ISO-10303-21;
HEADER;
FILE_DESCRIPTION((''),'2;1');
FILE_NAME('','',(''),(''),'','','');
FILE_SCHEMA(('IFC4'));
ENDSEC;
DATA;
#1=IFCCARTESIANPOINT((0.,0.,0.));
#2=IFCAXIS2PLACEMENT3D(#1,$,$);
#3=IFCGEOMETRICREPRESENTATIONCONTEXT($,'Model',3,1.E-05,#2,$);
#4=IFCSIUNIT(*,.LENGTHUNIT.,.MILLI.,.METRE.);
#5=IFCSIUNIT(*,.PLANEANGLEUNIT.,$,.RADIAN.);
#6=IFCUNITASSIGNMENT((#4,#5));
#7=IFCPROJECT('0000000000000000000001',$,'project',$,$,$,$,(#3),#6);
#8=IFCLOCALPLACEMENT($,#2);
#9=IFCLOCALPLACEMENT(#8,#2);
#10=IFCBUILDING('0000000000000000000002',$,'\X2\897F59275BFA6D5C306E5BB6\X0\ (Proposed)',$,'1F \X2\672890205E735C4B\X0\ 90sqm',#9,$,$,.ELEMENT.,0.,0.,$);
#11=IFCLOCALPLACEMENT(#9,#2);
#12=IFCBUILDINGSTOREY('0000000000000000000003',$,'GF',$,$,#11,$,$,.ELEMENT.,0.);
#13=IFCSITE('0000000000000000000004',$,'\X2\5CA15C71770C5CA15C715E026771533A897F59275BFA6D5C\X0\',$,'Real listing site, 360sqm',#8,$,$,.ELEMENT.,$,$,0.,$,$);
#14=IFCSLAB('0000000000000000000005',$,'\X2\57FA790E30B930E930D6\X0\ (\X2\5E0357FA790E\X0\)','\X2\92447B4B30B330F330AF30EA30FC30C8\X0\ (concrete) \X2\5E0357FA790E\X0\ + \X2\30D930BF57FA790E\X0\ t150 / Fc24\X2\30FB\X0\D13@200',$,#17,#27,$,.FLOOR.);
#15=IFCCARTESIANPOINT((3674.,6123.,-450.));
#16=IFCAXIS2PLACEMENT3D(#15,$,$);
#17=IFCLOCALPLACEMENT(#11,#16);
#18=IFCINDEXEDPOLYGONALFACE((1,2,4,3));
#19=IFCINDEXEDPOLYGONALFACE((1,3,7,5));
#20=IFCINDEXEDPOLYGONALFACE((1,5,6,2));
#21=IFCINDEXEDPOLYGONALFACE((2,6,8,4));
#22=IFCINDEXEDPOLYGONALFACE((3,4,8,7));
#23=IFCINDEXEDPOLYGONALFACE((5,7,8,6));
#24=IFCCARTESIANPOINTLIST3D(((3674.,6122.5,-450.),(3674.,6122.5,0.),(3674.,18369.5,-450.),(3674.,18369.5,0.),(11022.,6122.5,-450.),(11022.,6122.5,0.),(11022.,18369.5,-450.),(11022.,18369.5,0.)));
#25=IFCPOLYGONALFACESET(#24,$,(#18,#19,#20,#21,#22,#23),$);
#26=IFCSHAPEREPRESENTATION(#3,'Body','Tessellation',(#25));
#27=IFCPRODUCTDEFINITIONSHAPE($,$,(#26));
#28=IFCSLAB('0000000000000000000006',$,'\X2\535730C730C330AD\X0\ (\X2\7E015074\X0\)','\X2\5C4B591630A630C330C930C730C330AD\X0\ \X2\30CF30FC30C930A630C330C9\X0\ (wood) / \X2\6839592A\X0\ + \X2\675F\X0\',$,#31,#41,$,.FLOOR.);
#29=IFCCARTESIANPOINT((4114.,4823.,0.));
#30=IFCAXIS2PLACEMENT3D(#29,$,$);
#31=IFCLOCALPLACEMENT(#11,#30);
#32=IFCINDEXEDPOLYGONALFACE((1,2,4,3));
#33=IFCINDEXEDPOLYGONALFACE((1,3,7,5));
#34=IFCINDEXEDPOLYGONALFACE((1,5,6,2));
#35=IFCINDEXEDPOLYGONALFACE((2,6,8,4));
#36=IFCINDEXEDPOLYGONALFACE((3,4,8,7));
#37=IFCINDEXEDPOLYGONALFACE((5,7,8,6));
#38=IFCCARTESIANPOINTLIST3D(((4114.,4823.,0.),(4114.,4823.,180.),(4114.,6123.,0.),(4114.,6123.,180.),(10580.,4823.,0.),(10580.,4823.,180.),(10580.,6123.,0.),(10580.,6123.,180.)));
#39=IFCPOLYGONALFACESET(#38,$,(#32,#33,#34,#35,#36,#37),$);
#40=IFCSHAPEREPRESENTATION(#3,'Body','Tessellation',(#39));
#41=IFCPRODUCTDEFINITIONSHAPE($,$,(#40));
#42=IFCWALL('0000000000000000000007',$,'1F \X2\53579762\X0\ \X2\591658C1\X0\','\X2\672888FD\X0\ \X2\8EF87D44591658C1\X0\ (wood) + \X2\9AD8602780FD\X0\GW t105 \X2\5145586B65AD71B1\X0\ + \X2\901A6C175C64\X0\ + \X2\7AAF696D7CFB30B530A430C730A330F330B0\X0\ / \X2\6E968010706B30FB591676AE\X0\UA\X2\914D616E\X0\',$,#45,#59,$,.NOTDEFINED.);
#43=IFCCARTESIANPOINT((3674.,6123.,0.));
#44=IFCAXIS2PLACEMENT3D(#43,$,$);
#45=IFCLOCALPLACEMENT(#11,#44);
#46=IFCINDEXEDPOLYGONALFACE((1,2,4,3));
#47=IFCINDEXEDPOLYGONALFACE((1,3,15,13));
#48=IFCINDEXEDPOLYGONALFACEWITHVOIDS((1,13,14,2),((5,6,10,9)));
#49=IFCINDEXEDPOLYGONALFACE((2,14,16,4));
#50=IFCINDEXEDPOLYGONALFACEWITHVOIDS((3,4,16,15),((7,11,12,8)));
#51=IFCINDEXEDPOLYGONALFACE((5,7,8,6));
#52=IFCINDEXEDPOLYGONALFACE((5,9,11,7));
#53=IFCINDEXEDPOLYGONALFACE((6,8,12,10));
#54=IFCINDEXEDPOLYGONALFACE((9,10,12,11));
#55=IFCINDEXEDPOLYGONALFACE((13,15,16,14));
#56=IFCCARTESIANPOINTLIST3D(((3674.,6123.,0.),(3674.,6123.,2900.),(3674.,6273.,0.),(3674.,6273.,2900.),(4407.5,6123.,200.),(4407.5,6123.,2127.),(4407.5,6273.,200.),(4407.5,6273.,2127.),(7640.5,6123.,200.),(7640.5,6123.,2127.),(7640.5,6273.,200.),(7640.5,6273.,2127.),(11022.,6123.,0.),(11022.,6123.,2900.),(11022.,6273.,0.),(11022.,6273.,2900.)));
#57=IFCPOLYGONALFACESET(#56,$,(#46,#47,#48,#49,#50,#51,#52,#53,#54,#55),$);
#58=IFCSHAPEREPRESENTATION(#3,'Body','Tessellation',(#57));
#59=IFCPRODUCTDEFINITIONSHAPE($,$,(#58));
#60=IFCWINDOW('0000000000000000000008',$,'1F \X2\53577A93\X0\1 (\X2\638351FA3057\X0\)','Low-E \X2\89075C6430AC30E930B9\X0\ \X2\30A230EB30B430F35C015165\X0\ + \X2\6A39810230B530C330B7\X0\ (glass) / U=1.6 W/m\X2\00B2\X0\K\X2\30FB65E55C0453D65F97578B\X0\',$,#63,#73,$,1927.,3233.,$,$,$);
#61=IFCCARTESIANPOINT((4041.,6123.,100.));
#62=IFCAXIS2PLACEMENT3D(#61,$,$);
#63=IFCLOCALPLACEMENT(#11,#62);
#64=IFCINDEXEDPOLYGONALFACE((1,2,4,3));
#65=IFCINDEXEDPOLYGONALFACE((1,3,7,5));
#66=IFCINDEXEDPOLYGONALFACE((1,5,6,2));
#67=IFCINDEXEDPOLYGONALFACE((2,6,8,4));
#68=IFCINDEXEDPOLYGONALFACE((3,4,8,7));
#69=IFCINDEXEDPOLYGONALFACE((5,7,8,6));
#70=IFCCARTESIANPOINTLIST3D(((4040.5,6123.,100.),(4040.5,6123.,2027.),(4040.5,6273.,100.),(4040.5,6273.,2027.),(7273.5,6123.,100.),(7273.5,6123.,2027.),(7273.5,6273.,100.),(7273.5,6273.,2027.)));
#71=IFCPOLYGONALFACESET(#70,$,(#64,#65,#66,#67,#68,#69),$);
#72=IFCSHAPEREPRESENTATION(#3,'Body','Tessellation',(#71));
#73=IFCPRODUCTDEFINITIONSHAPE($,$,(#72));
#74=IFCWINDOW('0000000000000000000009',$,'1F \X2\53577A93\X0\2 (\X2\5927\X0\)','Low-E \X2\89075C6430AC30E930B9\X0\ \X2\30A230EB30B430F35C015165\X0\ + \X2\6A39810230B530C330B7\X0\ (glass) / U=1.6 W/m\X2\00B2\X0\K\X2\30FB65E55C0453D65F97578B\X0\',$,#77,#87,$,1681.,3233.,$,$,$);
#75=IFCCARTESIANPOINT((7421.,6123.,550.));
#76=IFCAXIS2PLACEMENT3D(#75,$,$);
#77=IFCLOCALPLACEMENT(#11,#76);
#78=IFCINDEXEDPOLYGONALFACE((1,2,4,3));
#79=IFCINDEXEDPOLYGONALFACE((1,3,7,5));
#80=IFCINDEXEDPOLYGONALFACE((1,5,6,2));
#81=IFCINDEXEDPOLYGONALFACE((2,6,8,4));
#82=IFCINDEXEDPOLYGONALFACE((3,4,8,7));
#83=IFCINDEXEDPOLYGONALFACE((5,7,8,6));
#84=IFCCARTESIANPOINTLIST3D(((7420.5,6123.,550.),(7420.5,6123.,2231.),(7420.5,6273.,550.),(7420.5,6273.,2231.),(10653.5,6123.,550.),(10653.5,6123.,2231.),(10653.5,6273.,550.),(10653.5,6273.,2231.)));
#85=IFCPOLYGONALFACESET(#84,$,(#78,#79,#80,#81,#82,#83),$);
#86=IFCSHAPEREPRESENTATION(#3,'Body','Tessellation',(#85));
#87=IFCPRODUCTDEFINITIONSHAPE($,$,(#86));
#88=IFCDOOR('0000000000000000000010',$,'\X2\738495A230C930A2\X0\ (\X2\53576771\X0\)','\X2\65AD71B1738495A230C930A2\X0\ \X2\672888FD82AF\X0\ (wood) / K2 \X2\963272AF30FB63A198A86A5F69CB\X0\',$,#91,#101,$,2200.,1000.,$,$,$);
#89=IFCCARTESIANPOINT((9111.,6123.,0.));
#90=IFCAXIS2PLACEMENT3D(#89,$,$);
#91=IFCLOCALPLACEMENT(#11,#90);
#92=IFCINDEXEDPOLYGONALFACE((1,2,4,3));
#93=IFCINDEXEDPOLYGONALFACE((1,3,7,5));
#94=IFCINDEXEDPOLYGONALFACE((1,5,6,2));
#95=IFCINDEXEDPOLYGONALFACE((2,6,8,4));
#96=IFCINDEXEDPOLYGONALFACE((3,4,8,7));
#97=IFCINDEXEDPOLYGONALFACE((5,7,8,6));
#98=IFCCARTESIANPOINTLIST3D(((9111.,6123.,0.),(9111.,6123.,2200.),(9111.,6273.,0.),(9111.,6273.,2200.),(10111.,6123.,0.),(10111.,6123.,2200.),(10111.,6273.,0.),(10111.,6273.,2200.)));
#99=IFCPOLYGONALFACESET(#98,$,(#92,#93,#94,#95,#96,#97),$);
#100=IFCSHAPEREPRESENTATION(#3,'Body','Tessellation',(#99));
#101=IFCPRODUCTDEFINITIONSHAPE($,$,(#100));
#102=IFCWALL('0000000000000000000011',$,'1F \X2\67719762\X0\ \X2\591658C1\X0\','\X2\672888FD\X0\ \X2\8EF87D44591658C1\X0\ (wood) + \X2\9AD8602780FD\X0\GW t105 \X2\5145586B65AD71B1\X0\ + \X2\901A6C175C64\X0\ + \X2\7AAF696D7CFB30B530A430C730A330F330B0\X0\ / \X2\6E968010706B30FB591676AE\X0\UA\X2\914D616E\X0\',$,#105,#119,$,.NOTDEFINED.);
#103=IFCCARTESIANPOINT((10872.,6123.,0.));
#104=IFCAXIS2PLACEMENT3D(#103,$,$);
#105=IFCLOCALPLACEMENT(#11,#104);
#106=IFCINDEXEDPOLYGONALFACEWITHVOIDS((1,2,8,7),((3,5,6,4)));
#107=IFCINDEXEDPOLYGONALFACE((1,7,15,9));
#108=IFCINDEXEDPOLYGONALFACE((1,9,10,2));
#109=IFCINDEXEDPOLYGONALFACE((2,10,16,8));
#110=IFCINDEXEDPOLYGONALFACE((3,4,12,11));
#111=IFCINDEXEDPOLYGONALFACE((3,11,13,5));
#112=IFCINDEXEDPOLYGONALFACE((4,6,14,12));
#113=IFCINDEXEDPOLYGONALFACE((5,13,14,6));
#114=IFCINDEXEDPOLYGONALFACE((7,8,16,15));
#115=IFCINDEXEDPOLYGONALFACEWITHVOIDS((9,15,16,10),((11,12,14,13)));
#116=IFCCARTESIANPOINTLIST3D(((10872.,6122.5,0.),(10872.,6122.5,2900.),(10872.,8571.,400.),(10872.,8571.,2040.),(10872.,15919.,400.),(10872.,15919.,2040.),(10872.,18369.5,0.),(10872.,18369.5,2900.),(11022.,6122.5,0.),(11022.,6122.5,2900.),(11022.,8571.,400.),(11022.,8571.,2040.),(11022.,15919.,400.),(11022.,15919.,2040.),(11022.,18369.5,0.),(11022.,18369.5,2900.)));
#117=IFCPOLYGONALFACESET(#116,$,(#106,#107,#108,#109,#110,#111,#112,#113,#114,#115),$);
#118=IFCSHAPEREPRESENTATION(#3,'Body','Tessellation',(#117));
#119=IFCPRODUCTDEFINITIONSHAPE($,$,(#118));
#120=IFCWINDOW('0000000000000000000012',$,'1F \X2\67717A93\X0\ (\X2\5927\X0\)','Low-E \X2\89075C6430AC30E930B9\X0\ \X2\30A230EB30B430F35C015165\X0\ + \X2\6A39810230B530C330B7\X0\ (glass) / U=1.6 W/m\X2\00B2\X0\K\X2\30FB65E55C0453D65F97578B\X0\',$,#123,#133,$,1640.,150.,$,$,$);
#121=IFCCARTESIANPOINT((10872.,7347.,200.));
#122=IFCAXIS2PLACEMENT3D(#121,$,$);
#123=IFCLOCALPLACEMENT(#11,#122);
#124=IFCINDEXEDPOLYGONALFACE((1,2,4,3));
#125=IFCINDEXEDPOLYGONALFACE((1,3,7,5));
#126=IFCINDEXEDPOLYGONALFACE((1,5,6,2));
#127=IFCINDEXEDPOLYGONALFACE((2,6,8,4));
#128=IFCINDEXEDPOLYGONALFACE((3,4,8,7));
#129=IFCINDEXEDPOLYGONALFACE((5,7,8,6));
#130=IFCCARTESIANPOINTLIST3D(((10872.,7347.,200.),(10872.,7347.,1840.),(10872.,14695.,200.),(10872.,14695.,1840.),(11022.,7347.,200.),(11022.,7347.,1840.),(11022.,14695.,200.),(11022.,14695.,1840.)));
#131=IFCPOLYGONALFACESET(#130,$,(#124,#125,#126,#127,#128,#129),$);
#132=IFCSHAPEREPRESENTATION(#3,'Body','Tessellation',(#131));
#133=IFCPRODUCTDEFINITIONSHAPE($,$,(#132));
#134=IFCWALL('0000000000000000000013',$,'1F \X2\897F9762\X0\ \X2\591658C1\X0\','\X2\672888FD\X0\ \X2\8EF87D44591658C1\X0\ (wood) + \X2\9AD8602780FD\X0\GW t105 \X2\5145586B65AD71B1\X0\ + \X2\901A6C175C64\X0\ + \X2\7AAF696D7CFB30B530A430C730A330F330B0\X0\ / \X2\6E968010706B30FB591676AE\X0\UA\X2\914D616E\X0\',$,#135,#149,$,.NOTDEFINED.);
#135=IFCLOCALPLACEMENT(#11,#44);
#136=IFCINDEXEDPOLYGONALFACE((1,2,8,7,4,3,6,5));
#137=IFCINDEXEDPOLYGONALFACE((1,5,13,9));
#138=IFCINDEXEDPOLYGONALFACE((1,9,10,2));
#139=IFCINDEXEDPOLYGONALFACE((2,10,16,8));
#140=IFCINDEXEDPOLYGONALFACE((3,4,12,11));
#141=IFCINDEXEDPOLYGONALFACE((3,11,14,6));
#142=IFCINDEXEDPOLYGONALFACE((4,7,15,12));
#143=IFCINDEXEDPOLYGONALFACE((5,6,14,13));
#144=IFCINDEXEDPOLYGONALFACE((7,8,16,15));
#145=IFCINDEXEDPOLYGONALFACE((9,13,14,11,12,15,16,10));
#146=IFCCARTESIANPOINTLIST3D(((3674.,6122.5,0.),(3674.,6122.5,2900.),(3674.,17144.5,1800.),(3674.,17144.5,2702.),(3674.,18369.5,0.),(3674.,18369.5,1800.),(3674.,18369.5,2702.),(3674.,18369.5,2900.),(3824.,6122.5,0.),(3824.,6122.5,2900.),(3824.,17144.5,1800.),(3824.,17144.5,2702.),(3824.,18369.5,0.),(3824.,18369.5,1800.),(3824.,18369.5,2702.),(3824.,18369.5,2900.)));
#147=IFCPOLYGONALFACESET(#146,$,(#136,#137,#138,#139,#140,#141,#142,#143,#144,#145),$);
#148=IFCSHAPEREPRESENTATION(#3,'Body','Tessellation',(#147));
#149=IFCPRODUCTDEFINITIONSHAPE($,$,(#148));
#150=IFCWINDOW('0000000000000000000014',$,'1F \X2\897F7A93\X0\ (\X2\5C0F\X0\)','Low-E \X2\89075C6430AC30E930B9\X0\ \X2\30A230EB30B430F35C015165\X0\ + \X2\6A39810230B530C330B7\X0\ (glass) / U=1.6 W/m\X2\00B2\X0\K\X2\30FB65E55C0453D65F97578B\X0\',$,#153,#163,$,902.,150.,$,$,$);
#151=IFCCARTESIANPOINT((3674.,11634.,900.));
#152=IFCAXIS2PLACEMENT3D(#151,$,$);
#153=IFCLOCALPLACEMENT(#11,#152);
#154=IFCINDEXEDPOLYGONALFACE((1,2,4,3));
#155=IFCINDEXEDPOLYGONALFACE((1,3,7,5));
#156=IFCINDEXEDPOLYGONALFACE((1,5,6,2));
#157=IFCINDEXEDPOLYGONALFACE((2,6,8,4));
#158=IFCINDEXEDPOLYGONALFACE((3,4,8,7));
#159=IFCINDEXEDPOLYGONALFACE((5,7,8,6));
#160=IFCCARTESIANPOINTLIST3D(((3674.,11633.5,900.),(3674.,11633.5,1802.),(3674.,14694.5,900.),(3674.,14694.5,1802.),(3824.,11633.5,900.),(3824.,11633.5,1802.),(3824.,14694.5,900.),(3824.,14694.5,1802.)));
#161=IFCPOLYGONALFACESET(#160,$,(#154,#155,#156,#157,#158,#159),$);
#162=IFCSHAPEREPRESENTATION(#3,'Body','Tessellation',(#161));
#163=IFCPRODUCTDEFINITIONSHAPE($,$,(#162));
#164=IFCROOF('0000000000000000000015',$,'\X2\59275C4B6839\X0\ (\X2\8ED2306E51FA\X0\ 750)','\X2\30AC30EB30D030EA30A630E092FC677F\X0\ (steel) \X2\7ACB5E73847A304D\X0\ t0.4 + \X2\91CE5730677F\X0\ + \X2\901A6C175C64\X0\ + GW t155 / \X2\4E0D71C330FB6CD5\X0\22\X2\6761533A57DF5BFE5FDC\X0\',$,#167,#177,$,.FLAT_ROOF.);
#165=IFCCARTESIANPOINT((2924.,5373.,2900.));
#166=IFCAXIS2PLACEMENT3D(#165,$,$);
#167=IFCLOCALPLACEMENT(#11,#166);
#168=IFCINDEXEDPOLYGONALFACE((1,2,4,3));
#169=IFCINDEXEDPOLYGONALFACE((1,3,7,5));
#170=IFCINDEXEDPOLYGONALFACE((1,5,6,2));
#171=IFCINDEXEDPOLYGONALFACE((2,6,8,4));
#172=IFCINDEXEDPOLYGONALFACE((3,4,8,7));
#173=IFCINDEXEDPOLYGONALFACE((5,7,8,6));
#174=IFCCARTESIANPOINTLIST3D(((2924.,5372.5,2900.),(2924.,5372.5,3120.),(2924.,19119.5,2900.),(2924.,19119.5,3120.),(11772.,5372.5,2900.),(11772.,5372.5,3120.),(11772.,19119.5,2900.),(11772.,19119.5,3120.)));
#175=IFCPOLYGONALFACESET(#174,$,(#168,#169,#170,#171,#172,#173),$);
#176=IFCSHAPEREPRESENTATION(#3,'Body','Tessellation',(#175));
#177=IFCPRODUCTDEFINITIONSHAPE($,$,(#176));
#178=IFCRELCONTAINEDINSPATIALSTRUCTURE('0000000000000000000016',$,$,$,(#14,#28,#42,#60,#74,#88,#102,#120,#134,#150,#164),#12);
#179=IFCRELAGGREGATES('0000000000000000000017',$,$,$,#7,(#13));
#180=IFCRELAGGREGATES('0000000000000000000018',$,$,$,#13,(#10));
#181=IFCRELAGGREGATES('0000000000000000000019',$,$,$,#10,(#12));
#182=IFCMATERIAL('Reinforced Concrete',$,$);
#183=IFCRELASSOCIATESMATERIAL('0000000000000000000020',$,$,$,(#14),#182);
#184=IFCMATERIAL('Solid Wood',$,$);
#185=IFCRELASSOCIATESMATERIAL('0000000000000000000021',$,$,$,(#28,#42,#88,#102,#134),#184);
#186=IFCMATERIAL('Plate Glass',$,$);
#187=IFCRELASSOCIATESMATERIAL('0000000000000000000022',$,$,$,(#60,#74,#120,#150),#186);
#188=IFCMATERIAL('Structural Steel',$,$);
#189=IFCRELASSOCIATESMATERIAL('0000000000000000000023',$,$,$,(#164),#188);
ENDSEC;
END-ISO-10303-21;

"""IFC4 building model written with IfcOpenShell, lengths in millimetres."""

from ifc_helpers import new_model, si_unit, frame, frame_2d, origin, place, context, project, spatial, rectangle, extrude, material, element, fill, save


model = new_model("IFC4")

# Units and contexts
model_context = context("Model", 3, precision=1e-05, world=origin())
ifc_project = project(units=[si_unit("LENGTHUNIT", "METRE", prefix="MILLI"), si_unit("PLANEANGLEUNIT", "RADIAN")], contexts=[model_context])

# Site, building, storey
site_placement = place(None, origin())
site = spatial("IfcSite", under=ifc_project, at=site_placement, Name="岡山県岡山市東区西大寺浜", ObjectType="Real listing site, 360sqm", CompositionType="ELEMENT", RefElevation=0.0)
building_placement = place(site_placement, origin())
building = spatial("IfcBuilding", under=site, at=building_placement, Name="西大寺浜の家 (Proposed)", ObjectType="1F 木造平屋 90sqm", CompositionType="ELEMENT", ElevationOfRefHeight=0.0, ElevationOfTerrain=0.0)
storey_placement = place(building_placement, origin())
storey = spatial("IfcBuildingStorey", under=building, at=storey_placement, Name="GF", CompositionType="ELEMENT", Elevation=0.0)

# Slabs
ifc_material_1 = material(Name="Reinforced Concrete")
slab_1_placement = place(storey_placement, frame((3674.0, 6123.0, -450.0)))
element("IfcSlab", 1, at=slab_1_placement, inside=storey, material=ifc_material_1, Name="基礎スラブ (布基礎)", Description="鉄筋コンクリート (concrete) 布基礎 + ベタ基礎 t150 / Fc24・D13@200", PredefinedType="FLOOR", context=model_context, shape_type="SweptSolid", body=[
    extrude(rectangle(XDim=7348.0, YDim=12247.0, at=frame_2d((3674.0, 6123.0))), frame((3674.0, 6123.0, -450.0)), (0.0, 0.0, 1.0), 450.0),
])
ifc_material_2 = material(Name="Solid Wood")
slab_2_placement = place(storey_placement, frame((4114.0, 4823.0, 0.0)))
element("IfcSlab", 2, at=slab_2_placement, inside=storey, material=ifc_material_2, Name="南デッキ (縁側)", Description="屋外ウッドデッキ ハードウッド (wood) / 根太 + 束", PredefinedType="FLOOR", context=model_context, shape_type="SweptSolid", body=[
    extrude(rectangle(XDim=6466.0, YDim=1300.0, at=frame_2d((3233.0, 650.0))), frame((4114.0, 4823.0, 0.0)), (0.0, 0.0, 1.0), 180.0),
])

# Wall, openings, windows, door
wall_1_placement = place(storey_placement, frame((3674.0, 6123.0, 0.0)))
wall_1 = element("IfcWall", 3, at=wall_1_placement, inside=storey, material=ifc_material_2, Name="1F 南面 外壁", Description="木製 軸組外壁 (wood) + 高性能GW t105 充填断熱 + 通気層 + 窯業系サイディング / 準耐火・外皮UA配慮", PredefinedType="NOTDEFINED", context=model_context, shape_type="SweptSolid", body=[
    extrude(rectangle(XDim=7348.0, YDim=150.0, at=frame_2d((3674.0, 75.0))), frame((3674.0, 6123.0, 0.0)), (0.0, 0.0, 1.0), 2900.0),
])
opening_1_placement = place(storey_placement, frame((4041.0, 6123.0, 100.0)))
opening_1 = element("IfcOpeningElement", 4, at=opening_1_placement, cuts=wall_1, PredefinedType="NOTDEFINED", context=model_context, shape_type="SweptSolid", body=[
    extrude(rectangle(XDim=3233.0, YDim=150.0, at=frame_2d((1616.0, 75.0))), frame((4041.0, 6123.0, 100.0)), (0.0, 0.0, 1.0), 1927.0),
])
opening_2_placement = place(storey_placement, frame((7421.0, 6123.0, 550.0)))
opening_2 = element("IfcOpeningElement", 5, at=opening_2_placement, cuts=wall_1, PredefinedType="NOTDEFINED", context=model_context, shape_type="SweptSolid", body=[
    extrude(rectangle(XDim=3233.0, YDim=150.0, at=frame_2d((1616.0, 75.0))), frame((7421.0, 6123.0, 550.0)), (0.0, 0.0, 1.0), 1681.0),
])
opening_3_placement = place(storey_placement, frame((9111.0, 6123.0, 0.0)))
opening_3 = element("IfcOpeningElement", 6, at=opening_3_placement, cuts=wall_1, PredefinedType="NOTDEFINED", context=model_context, shape_type="SweptSolid", body=[
    extrude(rectangle(XDim=1000.0, YDim=150.0, at=frame_2d((500.0, 75.0))), frame((9111.0, 6123.0, 0.0)), (0.0, 0.0, 1.0), 2200.0),
])
ifc_material_3 = material(Name="Plate Glass")
window_1_placement = place(storey_placement, frame((4041.0, 6123.0, 100.0)))
window_1 = element("IfcWindow", 7, at=window_1_placement, inside=storey, material=ifc_material_3, Name="1F 南窓1 (掃出し)", Description="Low-E 複層ガラス アルゴン封入 + 樹脂サッシ (glass) / U=1.6 W/m²K・日射取得型", OverallHeight=1927.0, OverallWidth=3233.0, context=model_context, shape_type="SweptSolid", body=[
    extrude(rectangle(XDim=3233.0, YDim=150.0, at=frame_2d((1616.0, 75.0))), frame((4041.0, 6123.0, 100.0)), (0.0, 0.0, 1.0), 1927.0),
])
fill(opening_1, window_1)
window_2_placement = place(storey_placement, frame((7421.0, 6123.0, 550.0)))
window_2 = element("IfcWindow", 8, at=window_2_placement, inside=storey, material=ifc_material_3, Name="1F 南窓2 (大)", Description="Low-E 複層ガラス アルゴン封入 + 樹脂サッシ (glass) / U=1.6 W/m²K・日射取得型", OverallHeight=1681.0, OverallWidth=3233.0, context=model_context, shape_type="SweptSolid", body=[
    extrude(rectangle(XDim=3233.0, YDim=150.0, at=frame_2d((1616.0, 75.0))), frame((7421.0, 6123.0, 550.0)), (0.0, 0.0, 1.0), 1681.0),
])
fill(opening_2, window_2)
door_placement = place(storey_placement, frame((9111.0, 6123.0, 0.0)))
door = element("IfcDoor", 9, at=door_placement, inside=storey, material=ifc_material_2, Name="玄関ドア (南東)", Description="断熱玄関ドア 木製芯 (wood) / K2 防犯・採風機構", OverallHeight=2200.0, OverallWidth=1000.0, context=model_context, shape_type="SweptSolid", body=[
    extrude(rectangle(XDim=1000.0, YDim=150.0, at=frame_2d((500.0, 75.0))), frame((9111.0, 6123.0, 0.0)), (0.0, 0.0, 1.0), 2200.0),
])
fill(opening_3, door)

# Walls, openings, windows
wall_2_placement = place(storey_placement, frame((10872.0, 6123.0, 0.0)))
wall_2 = element("IfcWall", 10, at=wall_2_placement, inside=storey, material=ifc_material_2, Name="1F 東面 外壁", Description="木製 軸組外壁 (wood) + 高性能GW t105 充填断熱 + 通気層 + 窯業系サイディング / 準耐火・外皮UA配慮", PredefinedType="NOTDEFINED", context=model_context, shape_type="SweptSolid", body=[
    extrude(rectangle(XDim=150.0, YDim=12247.0, at=frame_2d((75.0, 6123.0))), frame((10872.0, 6123.0, 0.0)), (0.0, 0.0, 1.0), 2900.0),
])
opening_4_placement = place(storey_placement, frame((10872.0, 7347.0, 200.0)))
opening_4 = element("IfcOpeningElement", 11, at=opening_4_placement, cuts=wall_2, PredefinedType="NOTDEFINED", context=model_context, shape_type="SweptSolid", body=[
    extrude(rectangle(XDim=150.0, YDim=7348.0, at=frame_2d((75.0, 3674.0))), frame((10872.0, 7347.0, 200.0)), (0.0, 0.0, 1.0), 1640.0),
])
window_3_placement = place(storey_placement, frame((10872.0, 7347.0, 200.0)))
window_3 = element("IfcWindow", 12, at=window_3_placement, inside=storey, material=ifc_material_3, Name="1F 東窓 (大)", Description="Low-E 複層ガラス アルゴン封入 + 樹脂サッシ (glass) / U=1.6 W/m²K・日射取得型", OverallHeight=1640.0, OverallWidth=150.0, context=model_context, shape_type="SweptSolid", body=[
    extrude(rectangle(XDim=150.0, YDim=7348.0, at=frame_2d((75.0, 3674.0))), frame((10872.0, 7347.0, 200.0)), (0.0, 0.0, 1.0), 1640.0),
])
fill(opening_4, window_3)
wall_3_placement = place(storey_placement, frame((3674.0, 6123.0, 0.0)))
wall_3 = element("IfcWall", 13, at=wall_3_placement, inside=storey, material=ifc_material_2, Name="1F 西面 外壁", Description="木製 軸組外壁 (wood) + 高性能GW t105 充填断熱 + 通気層 + 窯業系サイディング / 準耐火・外皮UA配慮", PredefinedType="NOTDEFINED", context=model_context, shape_type="SweptSolid", body=[
    extrude(rectangle(XDim=150.0, YDim=12247.0, at=frame_2d((75.0, 6123.0))), frame((3674.0, 6123.0, 0.0)), (0.0, 0.0, 1.0), 2900.0),
])
opening_5_placement = place(storey_placement, frame((3674.0, 11634.0, 900.0)))
opening_5 = element("IfcOpeningElement", 14, at=opening_5_placement, cuts=wall_3, PredefinedType="NOTDEFINED", context=model_context, shape_type="SweptSolid", body=[
    extrude(rectangle(XDim=150.0, YDim=3061.0, at=frame_2d((75.0, 1530.0))), frame((3674.0, 11634.0, 900.0)), (0.0, 0.0, 1.0), 902.0),
])
window_4_placement = place(storey_placement, frame((3674.0, 11634.0, 900.0)))
window_4 = element("IfcWindow", 15, at=window_4_placement, inside=storey, material=ifc_material_3, Name="1F 西窓 (小)", Description="Low-E 複層ガラス アルゴン封入 + 樹脂サッシ (glass) / U=1.6 W/m²K・日射取得型", OverallHeight=902.0, OverallWidth=150.0, context=model_context, shape_type="SweptSolid", body=[
    extrude(rectangle(XDim=150.0, YDim=3061.0, at=frame_2d((75.0, 1530.0))), frame((3674.0, 11634.0, 900.0)), (0.0, 0.0, 1.0), 902.0),
])
fill(opening_5, window_4)

# Roof
ifc_material_4 = material(Name="Structural Steel")
roof_placement = place(storey_placement, frame((2924.0, 5373.0, 2900.0)))
element("IfcRoof", 16, at=roof_placement, inside=storey, material=ifc_material_4, Name="大屋根 (軒の出 750)", Description="ガルバリウム鋼板 (steel) 立平葺き t0.4 + 野地板 + 通気層 + GW t155 / 不燃・法22条区域対応", PredefinedType="FLAT_ROOF", context=model_context, shape_type="SweptSolid", body=[
    extrude(rectangle(XDim=8848.0, YDim=13747.0, at=frame_2d((4424.0, 6873.0))), frame((2924.0, 5373.0, 2900.0)), (0.0, 0.0, 1.0), 220.0),
])

save(model, "model.ifc")
